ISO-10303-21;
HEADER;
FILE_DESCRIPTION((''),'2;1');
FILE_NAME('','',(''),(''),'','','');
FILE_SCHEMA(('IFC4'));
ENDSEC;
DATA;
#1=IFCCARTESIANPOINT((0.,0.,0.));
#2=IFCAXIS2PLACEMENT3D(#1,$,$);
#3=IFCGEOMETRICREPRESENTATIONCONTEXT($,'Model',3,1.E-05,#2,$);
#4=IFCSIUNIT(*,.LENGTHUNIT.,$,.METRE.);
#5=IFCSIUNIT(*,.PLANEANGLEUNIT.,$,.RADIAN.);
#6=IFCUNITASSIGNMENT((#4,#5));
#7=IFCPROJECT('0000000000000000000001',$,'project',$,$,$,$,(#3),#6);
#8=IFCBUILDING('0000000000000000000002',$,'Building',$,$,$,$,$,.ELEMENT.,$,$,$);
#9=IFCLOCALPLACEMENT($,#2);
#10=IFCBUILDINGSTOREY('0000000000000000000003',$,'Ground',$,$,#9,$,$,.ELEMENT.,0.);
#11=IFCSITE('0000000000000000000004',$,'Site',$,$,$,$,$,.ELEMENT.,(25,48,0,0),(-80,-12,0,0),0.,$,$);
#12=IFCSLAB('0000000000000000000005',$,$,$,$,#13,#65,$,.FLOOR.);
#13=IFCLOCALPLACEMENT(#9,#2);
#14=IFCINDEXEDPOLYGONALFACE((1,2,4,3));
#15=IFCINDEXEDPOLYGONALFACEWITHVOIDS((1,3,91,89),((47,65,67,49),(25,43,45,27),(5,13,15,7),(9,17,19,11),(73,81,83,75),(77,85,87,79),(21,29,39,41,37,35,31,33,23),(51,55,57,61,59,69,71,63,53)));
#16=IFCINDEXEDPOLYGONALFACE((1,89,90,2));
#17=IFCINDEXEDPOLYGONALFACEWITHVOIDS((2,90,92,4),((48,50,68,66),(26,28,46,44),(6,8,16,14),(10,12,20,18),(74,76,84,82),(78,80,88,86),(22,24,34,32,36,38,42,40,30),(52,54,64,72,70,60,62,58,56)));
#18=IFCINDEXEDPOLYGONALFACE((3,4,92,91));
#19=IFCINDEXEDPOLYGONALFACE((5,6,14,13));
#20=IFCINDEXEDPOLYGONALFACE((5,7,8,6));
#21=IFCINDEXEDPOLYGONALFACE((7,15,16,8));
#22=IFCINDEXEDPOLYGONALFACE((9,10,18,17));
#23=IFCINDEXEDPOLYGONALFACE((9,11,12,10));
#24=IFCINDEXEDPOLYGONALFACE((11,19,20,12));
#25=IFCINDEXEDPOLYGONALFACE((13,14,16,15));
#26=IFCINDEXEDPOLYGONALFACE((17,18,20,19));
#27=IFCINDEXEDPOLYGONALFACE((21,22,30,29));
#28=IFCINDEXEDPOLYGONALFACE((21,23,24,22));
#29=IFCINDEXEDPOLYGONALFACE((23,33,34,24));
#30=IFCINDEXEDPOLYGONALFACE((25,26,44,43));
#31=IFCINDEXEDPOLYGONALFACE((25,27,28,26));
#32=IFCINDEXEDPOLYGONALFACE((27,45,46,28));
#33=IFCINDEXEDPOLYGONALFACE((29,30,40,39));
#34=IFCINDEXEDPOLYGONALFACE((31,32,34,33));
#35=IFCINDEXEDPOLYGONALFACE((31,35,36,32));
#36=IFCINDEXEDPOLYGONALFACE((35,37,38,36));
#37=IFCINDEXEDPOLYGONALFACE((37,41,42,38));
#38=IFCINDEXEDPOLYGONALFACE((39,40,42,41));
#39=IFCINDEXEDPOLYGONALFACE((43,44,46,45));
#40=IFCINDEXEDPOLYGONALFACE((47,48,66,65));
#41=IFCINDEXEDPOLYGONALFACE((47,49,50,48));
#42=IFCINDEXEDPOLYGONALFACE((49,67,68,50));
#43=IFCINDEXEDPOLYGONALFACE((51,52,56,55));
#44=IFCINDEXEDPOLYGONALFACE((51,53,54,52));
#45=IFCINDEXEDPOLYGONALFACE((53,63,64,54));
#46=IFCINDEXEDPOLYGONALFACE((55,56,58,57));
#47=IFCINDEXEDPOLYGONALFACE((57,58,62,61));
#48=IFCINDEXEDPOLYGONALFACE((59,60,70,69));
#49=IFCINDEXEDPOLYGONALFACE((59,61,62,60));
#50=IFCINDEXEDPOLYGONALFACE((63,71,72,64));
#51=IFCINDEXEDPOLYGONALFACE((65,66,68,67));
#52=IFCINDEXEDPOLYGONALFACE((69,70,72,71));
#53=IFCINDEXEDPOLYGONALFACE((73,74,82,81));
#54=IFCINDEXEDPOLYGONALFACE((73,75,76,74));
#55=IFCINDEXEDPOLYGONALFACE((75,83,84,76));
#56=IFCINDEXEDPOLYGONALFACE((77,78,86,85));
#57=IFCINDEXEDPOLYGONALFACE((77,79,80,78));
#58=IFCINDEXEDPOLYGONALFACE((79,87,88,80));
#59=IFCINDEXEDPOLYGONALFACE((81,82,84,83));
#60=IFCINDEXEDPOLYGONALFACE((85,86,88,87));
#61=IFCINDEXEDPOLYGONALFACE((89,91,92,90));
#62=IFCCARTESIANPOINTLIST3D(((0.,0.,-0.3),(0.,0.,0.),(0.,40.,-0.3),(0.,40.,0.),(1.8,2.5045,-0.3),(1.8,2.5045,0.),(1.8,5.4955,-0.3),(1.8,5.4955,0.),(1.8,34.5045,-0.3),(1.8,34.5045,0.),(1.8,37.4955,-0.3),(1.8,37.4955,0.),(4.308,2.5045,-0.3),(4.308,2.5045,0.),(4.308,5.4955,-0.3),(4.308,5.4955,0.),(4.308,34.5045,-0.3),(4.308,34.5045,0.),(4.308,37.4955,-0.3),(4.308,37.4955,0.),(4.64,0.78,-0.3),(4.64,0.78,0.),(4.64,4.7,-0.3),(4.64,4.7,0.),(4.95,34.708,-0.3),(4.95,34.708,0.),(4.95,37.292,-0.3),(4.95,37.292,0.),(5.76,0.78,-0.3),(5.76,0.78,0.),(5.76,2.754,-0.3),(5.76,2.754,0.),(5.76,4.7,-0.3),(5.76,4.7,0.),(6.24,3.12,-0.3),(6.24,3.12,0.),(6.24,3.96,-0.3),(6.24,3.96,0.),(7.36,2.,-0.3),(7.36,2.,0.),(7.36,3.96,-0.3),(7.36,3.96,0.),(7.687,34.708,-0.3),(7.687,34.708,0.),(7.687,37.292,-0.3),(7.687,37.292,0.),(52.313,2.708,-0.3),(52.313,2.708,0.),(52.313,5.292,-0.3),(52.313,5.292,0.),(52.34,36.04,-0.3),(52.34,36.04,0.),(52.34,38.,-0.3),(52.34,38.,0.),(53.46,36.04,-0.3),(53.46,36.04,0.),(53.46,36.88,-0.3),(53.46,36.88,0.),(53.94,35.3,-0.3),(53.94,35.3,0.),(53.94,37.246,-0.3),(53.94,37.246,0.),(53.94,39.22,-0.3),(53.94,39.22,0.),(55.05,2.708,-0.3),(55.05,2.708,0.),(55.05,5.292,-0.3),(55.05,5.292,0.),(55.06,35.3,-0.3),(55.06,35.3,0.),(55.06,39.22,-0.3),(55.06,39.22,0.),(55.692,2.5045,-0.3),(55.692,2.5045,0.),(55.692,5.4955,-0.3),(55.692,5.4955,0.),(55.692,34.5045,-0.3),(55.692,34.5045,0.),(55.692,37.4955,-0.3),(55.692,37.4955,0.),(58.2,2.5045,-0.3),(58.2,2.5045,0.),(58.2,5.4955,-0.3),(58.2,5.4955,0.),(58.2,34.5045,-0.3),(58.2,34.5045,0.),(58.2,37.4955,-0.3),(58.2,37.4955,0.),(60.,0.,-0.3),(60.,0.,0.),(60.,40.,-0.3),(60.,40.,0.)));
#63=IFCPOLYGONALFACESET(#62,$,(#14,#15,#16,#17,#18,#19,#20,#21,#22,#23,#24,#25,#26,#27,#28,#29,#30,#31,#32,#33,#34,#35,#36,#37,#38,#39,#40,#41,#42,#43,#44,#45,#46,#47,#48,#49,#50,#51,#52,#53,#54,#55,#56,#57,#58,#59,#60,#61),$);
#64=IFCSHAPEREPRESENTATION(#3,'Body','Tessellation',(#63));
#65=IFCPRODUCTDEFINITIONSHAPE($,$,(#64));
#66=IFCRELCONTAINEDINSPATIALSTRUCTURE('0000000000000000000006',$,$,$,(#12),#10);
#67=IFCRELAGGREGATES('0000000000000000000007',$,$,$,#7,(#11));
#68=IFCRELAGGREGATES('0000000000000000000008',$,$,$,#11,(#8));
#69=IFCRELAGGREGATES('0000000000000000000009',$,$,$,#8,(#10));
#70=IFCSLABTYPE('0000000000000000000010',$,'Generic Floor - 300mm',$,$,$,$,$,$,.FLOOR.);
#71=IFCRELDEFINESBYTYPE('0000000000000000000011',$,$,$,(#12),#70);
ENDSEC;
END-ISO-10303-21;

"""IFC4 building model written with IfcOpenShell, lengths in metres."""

from ifc_helpers import new_model, si_unit, frame, origin, place, context, project, spatial, polyline, outline, extrude, type_object, element, save


model = new_model("IFC4")

# Units and contexts
model_context = context("Model", 3, precision=1e-05, world=origin())
ifc_project = project(units=[si_unit("LENGTHUNIT", "METRE"), si_unit("PLANEANGLEUNIT", "RADIAN")], contexts=[model_context])

# Site, building, storey
site = spatial("IfcSite", under=ifc_project, Name="Site", CompositionType="ELEMENT", RefLatitude=(25, 48, 0, 0), RefLongitude=(-80, -12, 0, 0), RefElevation=0.0)
building = spatial("IfcBuilding", under=site, Name="Building", CompositionType="ELEMENT")
storey_placement = place(None, origin())
storey = spatial("IfcBuildingStorey", under=building, at=storey_placement, Name="Ground", CompositionType="ELEMENT", Elevation=0.0)

# Slab, openings
slab_type = type_object("IfcSlabType", Name="Generic Floor - 300mm", PredefinedType="FLOOR")
slab_placement = place(None, origin())
slab = element("IfcSlab", 1, at=slab_placement, inside=storey, type_object=slab_type, PredefinedType="FLOOR", context=model_context, shape_type="SweptSolid", body=[
    extrude(outline(polyline([(0.0, 0.0), (60.0, 0.0), (60.0, 40.0), (0.0, 40.0), (0.0, 0.0)])), origin(), (0.0, 0.0, -1.0), 0.3),
])
opening_1_placement = place(None, frame((0.0, 0.0, 0.001)))
element("IfcOpeningElement", 2, at=opening_1_placement, cuts=slab, PredefinedType="OPENING", context=model_context, shape_type="SweptSolid", body=[
    extrude(outline(polyline([(4.64, 0.78), (5.76, 0.78), (7.36, 2.0), (7.36, 3.96), (6.24, 3.96), (6.24, 3.12), (5.76, 2.754), (5.76, 4.7), (4.64, 4.7), (4.64, 0.78)])), origin(), (0.0, 0.0, -1.0), 0.302),
])
opening_2_placement = place(None, frame((0.0, 0.0, 0.001)))
element("IfcOpeningElement", 3, at=opening_2_placement, cuts=slab, PredefinedType="OPENING", context=model_context, shape_type="SweptSolid", body=[
    extrude(outline(polyline([(52.34, 36.04), (53.46, 36.04), (53.46, 36.88), (53.94, 37.246), (53.94, 35.3), (55.06, 35.3), (55.06, 39.22), (53.94, 39.22), (52.34, 38.0), (52.34, 36.04)])), origin(), (0.0, 0.0, -1.0), 0.302),
])
opening_3_placement = place(None, frame((0.0, 0.0, 0.001)))
element("IfcOpeningElement", 4, at=opening_3_placement, cuts=slab, PredefinedType="OPENING", context=model_context, shape_type="SweptSolid", body=[
    extrude(outline(polyline([(1.8, 5.4955), (1.8, 2.5045), (4.308, 2.5045), (4.308, 5.4955), (1.8, 5.4955)])), origin(), (0.0, 0.0, -1.0), 0.302),
])
opening_4_placement = place(None, frame((0.0, 0.0, 0.001)))
element("IfcOpeningElement", 5, at=opening_4_placement, cuts=slab, PredefinedType="OPENING", context=model_context, shape_type="SweptSolid", body=[
    extrude(outline(polyline([(58.2, 2.5045), (58.2, 5.4955), (55.692, 5.4955), (55.692, 2.5045), (58.2, 2.5045)])), origin(), (0.0, 0.0, -1.0), 0.302),
])
opening_5_placement = place(None, frame((0.0, 0.0, 0.001)))
element("IfcOpeningElement", 6, at=opening_5_placement, cuts=slab, PredefinedType="OPENING", context=model_context, shape_type="SweptSolid", body=[
    extrude(outline(polyline([(55.05, 2.708), (55.05, 5.292), (52.313, 5.292), (52.313, 2.708), (55.05, 2.708)])), origin(), (0.0, 0.0, -1.0), 0.302),
])
opening_6_placement = place(None, frame((0.0, 0.0, 0.001)))
element("IfcOpeningElement", 7, at=opening_6_placement, cuts=slab, PredefinedType="OPENING", context=model_context, shape_type="SweptSolid", body=[
    extrude(outline(polyline([(1.8, 37.4955), (1.8, 34.5045), (4.308, 34.5045), (4.308, 37.4955), (1.8, 37.4955)])), origin(), (0.0, 0.0, -1.0), 0.302),
])
opening_7_placement = place(None, frame((0.0, 0.0, 0.001)))
element("IfcOpeningElement", 8, at=opening_7_placement, cuts=slab, PredefinedType="OPENING", context=model_context, shape_type="SweptSolid", body=[
    extrude(outline(polyline([(4.95, 37.292), (4.95, 34.708), (7.687, 34.708), (7.687, 37.292), (4.95, 37.292)])), origin(), (0.0, 0.0, -1.0), 0.302),
])
opening_8_placement = place(None, frame((0.0, 0.0, 0.001)))
element("IfcOpeningElement", 9, at=opening_8_placement, cuts=slab, PredefinedType="OPENING", context=model_context, shape_type="SweptSolid", body=[
    extrude(outline(polyline([(58.2, 34.5045), (58.2, 37.4955), (55.692, 37.4955), (55.692, 34.5045), (58.2, 34.5045)])), origin(), (0.0, 0.0, -1.0), 0.302),
])

save(model, "model.ifc")
